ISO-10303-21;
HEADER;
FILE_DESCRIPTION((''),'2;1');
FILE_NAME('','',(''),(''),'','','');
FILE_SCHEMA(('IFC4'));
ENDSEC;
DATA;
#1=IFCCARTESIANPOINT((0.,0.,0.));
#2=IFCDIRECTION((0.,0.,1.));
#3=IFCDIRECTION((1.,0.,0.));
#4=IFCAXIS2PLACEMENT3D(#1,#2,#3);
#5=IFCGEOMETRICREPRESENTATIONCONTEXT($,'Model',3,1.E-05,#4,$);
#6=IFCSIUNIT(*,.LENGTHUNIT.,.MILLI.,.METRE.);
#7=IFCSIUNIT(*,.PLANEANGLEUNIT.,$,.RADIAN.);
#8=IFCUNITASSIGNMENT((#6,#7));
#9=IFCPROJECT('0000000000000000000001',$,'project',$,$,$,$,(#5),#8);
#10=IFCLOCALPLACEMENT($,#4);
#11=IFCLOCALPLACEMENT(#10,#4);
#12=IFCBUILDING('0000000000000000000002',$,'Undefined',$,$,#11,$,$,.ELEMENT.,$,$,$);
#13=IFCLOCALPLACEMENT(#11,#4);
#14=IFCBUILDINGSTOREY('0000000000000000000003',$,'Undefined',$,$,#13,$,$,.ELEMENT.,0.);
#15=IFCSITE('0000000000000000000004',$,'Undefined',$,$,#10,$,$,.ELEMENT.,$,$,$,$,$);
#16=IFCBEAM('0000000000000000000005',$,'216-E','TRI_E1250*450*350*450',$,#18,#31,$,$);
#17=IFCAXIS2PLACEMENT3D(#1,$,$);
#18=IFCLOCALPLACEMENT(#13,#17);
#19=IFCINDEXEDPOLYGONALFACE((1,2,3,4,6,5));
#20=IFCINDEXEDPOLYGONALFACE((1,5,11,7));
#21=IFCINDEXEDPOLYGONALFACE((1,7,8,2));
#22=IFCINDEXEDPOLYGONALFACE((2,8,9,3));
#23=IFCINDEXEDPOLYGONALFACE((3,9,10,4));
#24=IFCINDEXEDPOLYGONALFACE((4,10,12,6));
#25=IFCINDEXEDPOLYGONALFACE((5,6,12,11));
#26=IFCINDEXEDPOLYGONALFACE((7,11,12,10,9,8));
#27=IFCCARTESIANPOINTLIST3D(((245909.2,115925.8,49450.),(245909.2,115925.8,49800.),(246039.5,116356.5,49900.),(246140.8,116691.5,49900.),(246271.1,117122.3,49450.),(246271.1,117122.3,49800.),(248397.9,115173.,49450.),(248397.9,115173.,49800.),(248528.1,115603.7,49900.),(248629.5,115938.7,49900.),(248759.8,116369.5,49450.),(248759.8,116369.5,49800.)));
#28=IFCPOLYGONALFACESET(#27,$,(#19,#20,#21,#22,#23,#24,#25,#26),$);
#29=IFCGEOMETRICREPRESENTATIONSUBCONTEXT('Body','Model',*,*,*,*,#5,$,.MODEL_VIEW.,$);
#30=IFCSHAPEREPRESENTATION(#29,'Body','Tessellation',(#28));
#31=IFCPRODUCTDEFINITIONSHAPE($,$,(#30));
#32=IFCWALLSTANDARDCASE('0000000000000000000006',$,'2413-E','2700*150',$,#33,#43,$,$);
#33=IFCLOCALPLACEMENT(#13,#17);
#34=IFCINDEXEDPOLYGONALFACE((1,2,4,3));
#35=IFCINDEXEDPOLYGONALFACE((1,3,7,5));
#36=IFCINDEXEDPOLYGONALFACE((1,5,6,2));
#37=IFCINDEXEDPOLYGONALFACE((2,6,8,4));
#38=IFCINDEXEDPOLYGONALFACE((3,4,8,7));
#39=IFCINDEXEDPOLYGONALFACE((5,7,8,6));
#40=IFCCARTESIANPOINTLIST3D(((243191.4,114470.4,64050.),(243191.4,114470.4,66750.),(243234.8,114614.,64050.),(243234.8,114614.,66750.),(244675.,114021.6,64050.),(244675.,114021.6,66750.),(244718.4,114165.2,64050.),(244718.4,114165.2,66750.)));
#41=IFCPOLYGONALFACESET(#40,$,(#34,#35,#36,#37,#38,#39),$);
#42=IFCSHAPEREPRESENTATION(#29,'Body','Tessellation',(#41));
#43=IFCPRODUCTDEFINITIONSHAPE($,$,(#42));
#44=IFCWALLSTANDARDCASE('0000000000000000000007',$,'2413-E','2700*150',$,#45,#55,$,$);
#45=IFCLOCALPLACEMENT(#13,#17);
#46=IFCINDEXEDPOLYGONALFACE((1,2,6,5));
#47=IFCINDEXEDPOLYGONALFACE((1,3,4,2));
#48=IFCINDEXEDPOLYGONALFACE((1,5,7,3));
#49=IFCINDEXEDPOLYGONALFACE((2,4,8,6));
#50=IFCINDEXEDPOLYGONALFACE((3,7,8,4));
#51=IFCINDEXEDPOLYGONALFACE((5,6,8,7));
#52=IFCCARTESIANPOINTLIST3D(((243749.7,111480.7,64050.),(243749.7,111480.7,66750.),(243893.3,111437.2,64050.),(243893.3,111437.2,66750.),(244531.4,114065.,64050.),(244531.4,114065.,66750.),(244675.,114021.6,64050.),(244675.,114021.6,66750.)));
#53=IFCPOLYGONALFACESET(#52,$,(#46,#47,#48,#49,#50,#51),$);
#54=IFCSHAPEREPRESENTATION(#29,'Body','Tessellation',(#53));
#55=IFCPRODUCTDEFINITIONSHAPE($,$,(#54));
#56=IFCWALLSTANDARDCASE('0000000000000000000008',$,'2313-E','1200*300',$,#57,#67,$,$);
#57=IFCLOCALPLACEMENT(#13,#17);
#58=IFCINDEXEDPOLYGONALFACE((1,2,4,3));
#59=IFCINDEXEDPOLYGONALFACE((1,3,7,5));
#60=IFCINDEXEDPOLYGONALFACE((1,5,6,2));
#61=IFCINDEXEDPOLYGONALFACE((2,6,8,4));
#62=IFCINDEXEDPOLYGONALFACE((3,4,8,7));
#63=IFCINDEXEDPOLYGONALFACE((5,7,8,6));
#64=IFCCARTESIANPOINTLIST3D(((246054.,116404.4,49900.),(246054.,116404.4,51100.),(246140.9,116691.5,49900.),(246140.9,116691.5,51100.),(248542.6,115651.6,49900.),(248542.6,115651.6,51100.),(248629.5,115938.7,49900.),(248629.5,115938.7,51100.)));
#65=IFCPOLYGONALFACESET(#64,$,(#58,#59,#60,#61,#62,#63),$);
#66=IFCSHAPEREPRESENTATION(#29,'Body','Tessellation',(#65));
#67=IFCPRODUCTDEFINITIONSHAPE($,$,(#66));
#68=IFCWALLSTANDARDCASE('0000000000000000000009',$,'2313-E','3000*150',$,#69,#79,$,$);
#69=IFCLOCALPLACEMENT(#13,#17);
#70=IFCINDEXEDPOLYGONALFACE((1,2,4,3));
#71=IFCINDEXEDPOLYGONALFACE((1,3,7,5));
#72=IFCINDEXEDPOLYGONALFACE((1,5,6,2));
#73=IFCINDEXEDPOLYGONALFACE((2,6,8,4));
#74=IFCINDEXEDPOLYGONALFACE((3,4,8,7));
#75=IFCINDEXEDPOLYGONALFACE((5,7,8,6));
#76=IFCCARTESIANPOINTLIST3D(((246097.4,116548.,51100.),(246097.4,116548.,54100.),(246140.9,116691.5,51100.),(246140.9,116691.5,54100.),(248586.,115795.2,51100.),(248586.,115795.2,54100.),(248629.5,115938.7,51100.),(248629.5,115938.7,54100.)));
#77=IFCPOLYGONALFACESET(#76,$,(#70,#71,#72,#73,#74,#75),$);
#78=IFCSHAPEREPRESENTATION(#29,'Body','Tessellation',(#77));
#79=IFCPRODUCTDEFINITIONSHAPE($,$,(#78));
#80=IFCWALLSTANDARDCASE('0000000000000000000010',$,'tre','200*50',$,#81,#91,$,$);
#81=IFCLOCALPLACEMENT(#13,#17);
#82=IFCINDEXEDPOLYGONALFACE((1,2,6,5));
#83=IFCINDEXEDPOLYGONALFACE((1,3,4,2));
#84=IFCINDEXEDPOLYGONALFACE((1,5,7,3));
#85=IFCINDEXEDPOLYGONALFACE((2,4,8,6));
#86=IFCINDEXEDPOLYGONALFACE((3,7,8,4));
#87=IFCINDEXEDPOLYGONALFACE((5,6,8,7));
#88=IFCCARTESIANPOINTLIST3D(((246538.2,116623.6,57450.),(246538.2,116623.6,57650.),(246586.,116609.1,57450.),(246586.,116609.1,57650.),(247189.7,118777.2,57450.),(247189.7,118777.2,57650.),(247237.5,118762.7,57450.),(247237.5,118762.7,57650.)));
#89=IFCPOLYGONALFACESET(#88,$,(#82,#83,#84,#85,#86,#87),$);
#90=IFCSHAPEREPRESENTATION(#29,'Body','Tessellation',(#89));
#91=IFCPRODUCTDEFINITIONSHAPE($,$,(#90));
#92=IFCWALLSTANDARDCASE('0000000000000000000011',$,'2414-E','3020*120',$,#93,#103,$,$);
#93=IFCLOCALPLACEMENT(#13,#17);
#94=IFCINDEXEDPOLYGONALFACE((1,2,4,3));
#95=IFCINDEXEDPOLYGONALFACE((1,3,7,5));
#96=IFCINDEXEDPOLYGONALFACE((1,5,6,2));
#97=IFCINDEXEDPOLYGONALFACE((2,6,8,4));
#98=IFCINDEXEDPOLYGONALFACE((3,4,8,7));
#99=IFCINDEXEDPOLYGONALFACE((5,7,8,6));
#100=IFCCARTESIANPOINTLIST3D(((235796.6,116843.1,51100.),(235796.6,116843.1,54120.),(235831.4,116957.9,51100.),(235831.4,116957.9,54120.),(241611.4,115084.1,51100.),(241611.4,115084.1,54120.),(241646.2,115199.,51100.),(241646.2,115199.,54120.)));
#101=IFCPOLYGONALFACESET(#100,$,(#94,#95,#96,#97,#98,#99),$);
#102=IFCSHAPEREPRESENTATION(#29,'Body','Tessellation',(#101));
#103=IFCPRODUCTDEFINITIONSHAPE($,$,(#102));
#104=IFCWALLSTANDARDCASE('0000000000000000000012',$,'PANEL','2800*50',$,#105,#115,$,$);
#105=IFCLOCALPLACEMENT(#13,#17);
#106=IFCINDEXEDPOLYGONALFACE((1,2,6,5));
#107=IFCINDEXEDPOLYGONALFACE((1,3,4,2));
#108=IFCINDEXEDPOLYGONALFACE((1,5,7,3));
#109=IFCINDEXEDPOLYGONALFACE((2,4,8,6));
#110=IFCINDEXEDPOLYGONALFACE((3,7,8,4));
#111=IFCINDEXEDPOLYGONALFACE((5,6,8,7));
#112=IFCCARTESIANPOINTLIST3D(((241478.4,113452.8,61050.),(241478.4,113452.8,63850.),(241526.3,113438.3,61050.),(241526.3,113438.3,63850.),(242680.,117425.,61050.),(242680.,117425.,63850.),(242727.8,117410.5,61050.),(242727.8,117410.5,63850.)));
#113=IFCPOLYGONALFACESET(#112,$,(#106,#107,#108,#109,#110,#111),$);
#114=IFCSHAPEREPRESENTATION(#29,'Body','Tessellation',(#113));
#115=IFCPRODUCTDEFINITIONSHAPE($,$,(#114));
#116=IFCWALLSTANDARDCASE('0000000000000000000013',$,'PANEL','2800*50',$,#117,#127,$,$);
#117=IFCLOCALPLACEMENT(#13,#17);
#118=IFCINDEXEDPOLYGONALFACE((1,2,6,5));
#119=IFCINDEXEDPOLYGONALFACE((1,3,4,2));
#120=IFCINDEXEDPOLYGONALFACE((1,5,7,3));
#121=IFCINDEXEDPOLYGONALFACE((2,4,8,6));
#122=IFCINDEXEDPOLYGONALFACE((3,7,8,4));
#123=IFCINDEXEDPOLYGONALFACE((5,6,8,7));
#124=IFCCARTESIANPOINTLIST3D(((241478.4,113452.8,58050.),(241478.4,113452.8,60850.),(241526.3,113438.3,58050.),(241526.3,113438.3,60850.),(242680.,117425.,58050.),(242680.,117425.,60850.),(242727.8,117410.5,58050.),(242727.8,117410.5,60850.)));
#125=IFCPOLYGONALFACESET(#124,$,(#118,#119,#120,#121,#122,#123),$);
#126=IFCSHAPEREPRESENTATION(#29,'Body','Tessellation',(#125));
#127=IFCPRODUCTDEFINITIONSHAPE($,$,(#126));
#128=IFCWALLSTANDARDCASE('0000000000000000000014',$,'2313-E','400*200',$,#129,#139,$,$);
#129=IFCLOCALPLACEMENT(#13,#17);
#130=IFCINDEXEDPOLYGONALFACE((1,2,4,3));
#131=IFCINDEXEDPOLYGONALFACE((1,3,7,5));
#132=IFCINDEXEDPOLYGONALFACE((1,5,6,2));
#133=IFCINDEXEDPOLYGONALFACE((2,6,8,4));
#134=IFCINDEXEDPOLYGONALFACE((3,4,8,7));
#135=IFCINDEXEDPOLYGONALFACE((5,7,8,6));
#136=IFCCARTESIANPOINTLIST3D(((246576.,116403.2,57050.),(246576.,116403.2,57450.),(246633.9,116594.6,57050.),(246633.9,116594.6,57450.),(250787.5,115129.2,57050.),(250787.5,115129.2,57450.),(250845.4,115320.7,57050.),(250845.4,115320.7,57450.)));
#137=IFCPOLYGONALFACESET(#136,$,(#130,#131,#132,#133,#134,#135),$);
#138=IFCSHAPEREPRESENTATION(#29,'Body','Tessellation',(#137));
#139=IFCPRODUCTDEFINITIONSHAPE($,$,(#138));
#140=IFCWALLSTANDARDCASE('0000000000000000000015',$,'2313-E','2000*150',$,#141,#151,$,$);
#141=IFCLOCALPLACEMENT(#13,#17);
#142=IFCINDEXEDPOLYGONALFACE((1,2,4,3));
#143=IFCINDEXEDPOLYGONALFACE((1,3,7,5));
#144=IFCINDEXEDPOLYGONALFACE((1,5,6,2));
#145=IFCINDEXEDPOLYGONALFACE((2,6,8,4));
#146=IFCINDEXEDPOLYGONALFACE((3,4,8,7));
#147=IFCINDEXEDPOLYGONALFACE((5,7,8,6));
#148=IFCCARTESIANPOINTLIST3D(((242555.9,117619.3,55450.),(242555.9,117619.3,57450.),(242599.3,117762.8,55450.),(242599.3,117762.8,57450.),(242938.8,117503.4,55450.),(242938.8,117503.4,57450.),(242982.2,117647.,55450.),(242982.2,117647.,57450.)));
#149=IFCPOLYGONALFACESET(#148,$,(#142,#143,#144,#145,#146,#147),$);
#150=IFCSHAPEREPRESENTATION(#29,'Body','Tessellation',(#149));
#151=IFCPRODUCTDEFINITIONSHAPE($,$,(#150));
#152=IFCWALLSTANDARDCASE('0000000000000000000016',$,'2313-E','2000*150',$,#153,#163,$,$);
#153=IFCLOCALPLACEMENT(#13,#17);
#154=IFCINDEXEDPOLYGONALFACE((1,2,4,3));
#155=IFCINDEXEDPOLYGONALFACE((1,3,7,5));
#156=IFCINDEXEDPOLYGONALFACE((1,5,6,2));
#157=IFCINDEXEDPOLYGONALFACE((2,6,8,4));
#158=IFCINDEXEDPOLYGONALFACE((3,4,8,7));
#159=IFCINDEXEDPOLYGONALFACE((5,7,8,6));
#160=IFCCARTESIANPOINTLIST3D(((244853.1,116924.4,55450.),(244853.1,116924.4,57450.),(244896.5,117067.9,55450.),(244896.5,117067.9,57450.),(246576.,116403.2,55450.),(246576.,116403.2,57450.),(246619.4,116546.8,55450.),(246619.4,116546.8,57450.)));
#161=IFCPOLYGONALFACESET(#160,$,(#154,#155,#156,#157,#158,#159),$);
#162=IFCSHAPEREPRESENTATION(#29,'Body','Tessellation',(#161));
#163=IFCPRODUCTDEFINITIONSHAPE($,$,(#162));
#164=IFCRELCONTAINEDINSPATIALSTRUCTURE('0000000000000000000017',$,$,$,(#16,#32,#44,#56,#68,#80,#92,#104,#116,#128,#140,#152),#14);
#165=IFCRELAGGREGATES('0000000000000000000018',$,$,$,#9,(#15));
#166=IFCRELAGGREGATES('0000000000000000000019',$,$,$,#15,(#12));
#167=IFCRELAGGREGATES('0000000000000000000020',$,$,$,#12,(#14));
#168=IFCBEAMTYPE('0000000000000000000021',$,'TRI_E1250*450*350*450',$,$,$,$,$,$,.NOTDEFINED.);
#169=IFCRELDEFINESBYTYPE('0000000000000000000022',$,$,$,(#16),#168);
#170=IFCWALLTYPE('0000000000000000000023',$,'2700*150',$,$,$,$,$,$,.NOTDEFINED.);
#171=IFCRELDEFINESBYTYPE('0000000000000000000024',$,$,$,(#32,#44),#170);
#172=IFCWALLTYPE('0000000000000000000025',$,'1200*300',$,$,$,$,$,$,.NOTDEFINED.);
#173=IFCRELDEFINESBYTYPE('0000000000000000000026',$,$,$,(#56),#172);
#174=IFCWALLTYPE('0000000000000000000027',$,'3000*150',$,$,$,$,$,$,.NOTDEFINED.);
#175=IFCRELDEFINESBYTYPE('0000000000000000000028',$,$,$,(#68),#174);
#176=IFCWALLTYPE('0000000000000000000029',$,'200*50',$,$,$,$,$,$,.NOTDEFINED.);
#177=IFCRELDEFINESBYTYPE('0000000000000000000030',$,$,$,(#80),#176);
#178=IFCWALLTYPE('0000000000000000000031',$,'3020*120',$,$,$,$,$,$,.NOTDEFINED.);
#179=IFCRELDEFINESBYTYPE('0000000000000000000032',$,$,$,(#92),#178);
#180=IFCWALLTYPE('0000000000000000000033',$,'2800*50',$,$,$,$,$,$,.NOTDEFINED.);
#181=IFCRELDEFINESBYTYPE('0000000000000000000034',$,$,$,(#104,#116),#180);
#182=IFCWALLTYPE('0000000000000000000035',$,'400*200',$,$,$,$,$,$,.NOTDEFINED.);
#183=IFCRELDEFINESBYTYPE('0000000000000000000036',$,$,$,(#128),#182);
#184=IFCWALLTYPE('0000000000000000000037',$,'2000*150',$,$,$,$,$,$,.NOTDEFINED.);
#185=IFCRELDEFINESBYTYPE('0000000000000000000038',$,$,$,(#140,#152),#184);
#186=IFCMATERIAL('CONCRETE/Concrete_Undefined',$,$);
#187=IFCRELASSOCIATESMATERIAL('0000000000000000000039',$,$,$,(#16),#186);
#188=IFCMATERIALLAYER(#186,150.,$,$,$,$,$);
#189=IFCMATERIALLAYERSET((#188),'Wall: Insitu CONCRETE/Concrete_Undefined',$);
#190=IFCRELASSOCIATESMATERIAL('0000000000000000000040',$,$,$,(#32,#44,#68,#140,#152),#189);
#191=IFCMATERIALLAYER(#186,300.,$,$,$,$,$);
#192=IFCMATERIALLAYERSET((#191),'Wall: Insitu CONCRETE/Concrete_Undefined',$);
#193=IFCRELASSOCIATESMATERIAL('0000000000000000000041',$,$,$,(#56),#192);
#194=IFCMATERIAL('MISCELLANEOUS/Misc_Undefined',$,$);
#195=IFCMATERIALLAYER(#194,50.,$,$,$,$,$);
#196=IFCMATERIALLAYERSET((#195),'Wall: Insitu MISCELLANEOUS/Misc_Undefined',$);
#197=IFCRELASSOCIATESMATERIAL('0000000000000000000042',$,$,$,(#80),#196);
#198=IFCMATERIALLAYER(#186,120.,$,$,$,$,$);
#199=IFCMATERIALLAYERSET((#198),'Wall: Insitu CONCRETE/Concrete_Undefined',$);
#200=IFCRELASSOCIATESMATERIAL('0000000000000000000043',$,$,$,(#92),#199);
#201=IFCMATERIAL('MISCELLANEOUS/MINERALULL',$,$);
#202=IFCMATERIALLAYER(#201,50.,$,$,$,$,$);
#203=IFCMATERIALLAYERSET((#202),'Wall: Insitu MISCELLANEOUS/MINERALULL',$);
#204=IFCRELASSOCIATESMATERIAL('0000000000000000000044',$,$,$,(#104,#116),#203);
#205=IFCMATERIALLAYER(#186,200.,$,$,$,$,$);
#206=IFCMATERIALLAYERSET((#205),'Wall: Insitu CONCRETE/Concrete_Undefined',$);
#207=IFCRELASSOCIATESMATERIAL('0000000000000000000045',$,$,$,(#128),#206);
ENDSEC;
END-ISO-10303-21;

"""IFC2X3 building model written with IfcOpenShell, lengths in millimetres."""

from ifc_helpers import new_model, si_unit, frame, frame_2d, origin_with_axes, place, context, subcontext, project, spatial, polyline, rectangle, outline, extrude, material, layer, layer_set, layer_usage, type_object, element, save


model = new_model("IFC2X3")

# Units and contexts
model_context = context("Model", 3, precision=1e-05, world=origin_with_axes())
body_context = subcontext(model_context, "Body", "Model", "MODEL_VIEW")
ifc_project = project(units=[si_unit("LENGTHUNIT", "METRE", prefix="MILLI"), si_unit("PLANEANGLEUNIT", "RADIAN")], contexts=[model_context])

# Site, building, storey
site_placement = place(None, origin_with_axes())
site = spatial("IfcSite", under=ifc_project, at=site_placement, Name="Undefined", CompositionType="ELEMENT")
building_placement = place(site_placement, origin_with_axes())
building = spatial("IfcBuilding", under=site, at=building_placement, Name="Undefined", CompositionType="ELEMENT")
storey_placement = place(building_placement, origin_with_axes())
storey = spatial("IfcBuildingStorey", under=building, at=storey_placement, Name="Undefined", CompositionType="ELEMENT", Elevation=0.0)

# Beam
ifc_material_1 = material(Name="MISCELLANEOUS/Misc_Undefined")
ifc_material_2 = material(Name="CONCRETE/Concrete_Undefined")
beam_type_1 = type_object("IfcBeamType", Name="TRI_E1250*450*350*450", PredefinedType="NOTDEFINED")
beam_1_placement = place(storey_placement, frame((246090.2, 116524.0, 49675.0), z_axis=(0.0, 0.0, 1.0), x_axis=(0.957167, -0.289538, 0.0)))
element("IfcBeam", 1, at=beam_1_placement, inside=storey, type_object=beam_type_1, material=ifc_material_2, Name="216-E", Description="TRI_E1250*450*350*450", context=body_context, shape_type="SweptSolid", body=[
    extrude(outline(polyline([(625.0, -225.0), (-625.0, -225.0), (-625.0, 125.0), (-175.0, 225.0), (175.0, 225.0), (625.0, 125.0), (625.0, -225.0)])), frame((2600.0, 0.0, 0.0), z_axis=(-1.0, 0.0, 0.0), x_axis=(0.0, -1.0, 0.0)), (0.0, 0.0, 1.0), 2600.0),
])

# Walls
ifc_layer_1 = layer(ifc_material_2, 150.0)
ifc_layer_set_1 = layer_set([ifc_layer_1], Name="Wall: Insitu CONCRETE/Concrete_Undefined")
ifc_layer_usage_1 = layer_usage(ifc_layer_set_1, "AXIS2", "POSITIVE", -75.0)
wall_type_1 = type_object("IfcWallType", Name="2700*150", PredefinedType="NOTDEFINED")
wall_1_placement = place(storey_placement, frame((243213.1, 114542.2, 64050.0), z_axis=(0.0, 0.0, 1.0), x_axis=(0.957168, -0.289533, 0.0)))
element("IfcWallStandardCase", 2, at=wall_1_placement, inside=storey, type_object=wall_type_1, material=ifc_layer_usage_1, Name="2413-E", Description="2700*150", context=body_context, shape_type="SweptSolid", body=[
    extrude(rectangle(XDim=1550.0, YDim=150.0, at=frame_2d((0.0, 775.0), x_axis=(0.0, -1.0))), frame((0.0, 0.0, 0.0), z_axis=(0.0, 0.0, 1.0), x_axis=(0.0, -1.0, 0.0)), (0.0, 0.0, 1.0), 2700.0),
])
ifc_layer_usage_2 = layer_usage(ifc_layer_set_1, "AXIS2", "POSITIVE", -75.0)
wall_2_placement = place(storey_placement, frame((244603.2, 114043.3, 64050.0), z_axis=(0.0, 0.0, 1.0), x_axis=(-0.289536, -0.957167, 0.0)))
element("IfcWallStandardCase", 3, at=wall_2_placement, inside=storey, type_object=wall_type_1, material=ifc_layer_usage_2, Name="2413-E", Description="2700*150", context=body_context, shape_type="SweptSolid", body=[
    extrude(rectangle(XDim=2700.0, YDim=150.0, at=frame_2d((0.0, 1350.0), x_axis=(0.0, -1.0))), frame((0.0, 0.0, 0.0), z_axis=(0.0, 0.0, 1.0), x_axis=(0.0, -1.0, 0.0)), (0.0, 0.0, 1.0), 2700.0),
])
ifc_layer_2 = layer(ifc_material_2, 300.0)
ifc_layer_set_2 = layer_set([ifc_layer_2], Name="Wall: Insitu CONCRETE/Concrete_Undefined")
ifc_layer_usage_3 = layer_usage(ifc_layer_set_2, "AXIS2", "POSITIVE", -150.0)
wall_type_2 = type_object("IfcWallType", Name="1200*300", PredefinedType="NOTDEFINED")
wall_3_placement = place(storey_placement, frame((246097.4, 116548.0, 49900.0), z_axis=(0.0, 0.0, 1.0), x_axis=(0.957166, -0.289541, 0.0)))
element("IfcWallStandardCase", 4, at=wall_3_placement, inside=storey, type_object=wall_type_2, material=ifc_layer_usage_3, Name="2313-E", Description="1200*300", context=body_context, shape_type="SweptSolid", body=[
    extrude(rectangle(XDim=2600.0, YDim=300.0, at=frame_2d((0.0, 1300.0), x_axis=(0.0, -1.0))), frame((0.0, 0.0, 0.0), z_axis=(0.0, 0.0, 1.0), x_axis=(0.0, -1.0, 0.0)), (0.0, 0.0, 1.0), 1200.0),
])
ifc_layer_usage_4 = layer_usage(ifc_layer_set_1, "AXIS2", "POSITIVE", -75.0)
wall_type_3 = type_object("IfcWallType", Name="3000*150", PredefinedType="NOTDEFINED")
wall_4_placement = place(storey_placement, frame((246119.1, 116619.8, 51100.0), z_axis=(0.0, 0.0, 1.0), x_axis=(0.957166, -0.289541, 0.0)))
element("IfcWallStandardCase", 5, at=wall_4_placement, inside=storey, type_object=wall_type_3, material=ifc_layer_usage_4, Name="2313-E", Description="3000*150", context=body_context, shape_type="SweptSolid", body=[
    extrude(rectangle(XDim=2600.0, YDim=150.0, at=frame_2d((0.0, 1300.0), x_axis=(0.0, -1.0))), frame((0.0, 0.0, 0.0), z_axis=(0.0, 0.0, 1.0), x_axis=(0.0, -1.0, 0.0)), (0.0, 0.0, 1.0), 3000.0),
])
ifc_layer_3 = layer(ifc_material_1, 50.0)
ifc_layer_set_3 = layer_set([ifc_layer_3], Name="Wall: Insitu MISCELLANEOUS/Misc_Undefined")
ifc_layer_usage_5 = layer_usage(ifc_layer_set_3, "AXIS2", "POSITIVE", -25.0)
wall_type_4 = type_object("IfcWallType", Name="200*50", PredefinedType="NOTDEFINED")
wall_5_placement = place(storey_placement, frame((247213.6, 118770.0, 57450.0), z_axis=(0.0, 0.0, 1.0), x_axis=(-0.289539, -0.957166, 0.0)))
element("IfcWallStandardCase", 6, at=wall_5_placement, inside=storey, type_object=wall_type_4, material=ifc_layer_usage_5, Name="tre", Description="200*50", context=body_context, shape_type="SweptSolid", body=[
    extrude(rectangle(XDim=2250.0, YDim=50.0, at=frame_2d((0.0, 1125.0), x_axis=(0.0, -1.0))), frame((0.0, 0.0, 0.0), z_axis=(0.0, 0.0, 1.0), x_axis=(0.0, -1.0, 0.0)), (0.0, 0.0, 1.0), 200.0),
])
ifc_layer_4 = layer(ifc_material_2, 120.0)
ifc_layer_set_4 = layer_set([ifc_layer_4], Name="Wall: Insitu CONCRETE/Concrete_Undefined")
ifc_layer_usage_6 = layer_usage(ifc_layer_set_4, "AXIS2", "POSITIVE", -60.0)
wall_type_5 = type_object("IfcWallType", Name="3020*120", PredefinedType="NOTDEFINED")
wall_6_placement = place(storey_placement, frame((241628.8, 115141.5, 51100.0), z_axis=(0.0, 0.0, 1.0), x_axis=(-0.957166, 0.289541, 0.0)))
element("IfcWallStandardCase", 7, at=wall_6_placement, inside=storey, type_object=wall_type_5, material=ifc_layer_usage_6, Name="2414-E", Description="3020*120", context=body_context, shape_type="SweptSolid", body=[
    extrude(rectangle(XDim=6075.0, YDim=120.0, at=frame_2d((0.0, 3037.5), x_axis=(0.0, -1.0))), frame((0.0, 0.0, 0.0), z_axis=(0.0, 0.0, 1.0), x_axis=(0.0, -1.0, 0.0)), (0.0, 0.0, 1.0), 3020.0),
])
ifc_material_3 = material(Name="MISCELLANEOUS/MINERALULL")
ifc_layer_5 = layer(ifc_material_3, 50.0)
ifc_layer_set_5 = layer_set([ifc_layer_5], Name="Wall: Insitu MISCELLANEOUS/MINERALULL")
ifc_layer_usage_7 = layer_usage(ifc_layer_set_5, "AXIS2", "POSITIVE", -25.0)
wall_type_6 = type_object("IfcWallType", Name="2800*50", PredefinedType="NOTDEFINED")
wall_7_placement = place(storey_placement, frame((241502.3, 113445.5, 61050.0), z_axis=(0.0, 0.0, 1.0), x_axis=(0.289537, 0.957167, 0.0)))
element("IfcWallStandardCase", 8, at=wall_7_placement, inside=storey, type_object=wall_type_6, material=ifc_layer_usage_7, Name="PANEL", Description="2800*50", context=body_context, shape_type="SweptSolid", body=[
    extrude(rectangle(XDim=4150.0, YDim=50.0, at=frame_2d((0.0, 2075.0), x_axis=(0.0, -1.0))), frame((0.0, 0.0, 0.0), z_axis=(0.0, 0.0, 1.0), x_axis=(0.0, -1.0, 0.0)), (0.0, 0.0, 1.0), 2800.0),
])
ifc_layer_usage_8 = layer_usage(ifc_layer_set_5, "AXIS2", "POSITIVE", -25.0)
wall_8_placement = place(storey_placement, frame((241502.3, 113445.5, 58050.0), z_axis=(0.0, 0.0, 1.0), x_axis=(0.289537, 0.957167, 0.0)))
element("IfcWallStandardCase", 9, at=wall_8_placement, inside=storey, type_object=wall_type_6, material=ifc_layer_usage_8, Name="PANEL", Description="2800*50", context=body_context, shape_type="SweptSolid", body=[
    extrude(rectangle(XDim=4150.0, YDim=50.0, at=frame_2d((0.0, 2075.0), x_axis=(0.0, -1.0))), frame((0.0, 0.0, 0.0), z_axis=(0.0, 0.0, 1.0), x_axis=(0.0, -1.0, 0.0)), (0.0, 0.0, 1.0), 2800.0),
])
ifc_layer_6 = layer(ifc_material_2, 200.0)
ifc_layer_set_6 = layer_set([ifc_layer_6], Name="Wall: Insitu CONCRETE/Concrete_Undefined")
ifc_layer_usage_9 = layer_usage(ifc_layer_set_6, "AXIS2", "POSITIVE", -100.0)
wall_type_7 = type_object("IfcWallType", Name="400*200", PredefinedType="NOTDEFINED")
wall_9_placement = place(storey_placement, frame((246605.0, 116498.9, 57050.0), z_axis=(0.0, 0.0, 1.0), x_axis=(0.957166, -0.289539, 0.0)))
element("IfcWallStandardCase", 10, at=wall_9_placement, inside=storey, type_object=wall_type_7, material=ifc_layer_usage_9, Name="2313-E", Description="400*200", context=body_context, shape_type="SweptSolid", body=[
    extrude(rectangle(XDim=4400.0, YDim=200.0, at=frame_2d((0.0, 2200.0), x_axis=(0.0, -1.0))), frame((0.0, 0.0, 0.0), z_axis=(0.0, 0.0, 1.0), x_axis=(0.0, -1.0, 0.0)), (0.0, 0.0, 1.0), 400.0),
])
ifc_layer_usage_10 = layer_usage(ifc_layer_set_1, "AXIS2", "POSITIVE", -75.0)
wall_type_8 = type_object("IfcWallType", Name="2000*150", PredefinedType="NOTDEFINED")
wall_10_placement = place(storey_placement, frame((242577.6, 117691.0, 55450.0), z_axis=(0.0, 0.0, 1.0), x_axis=(0.957161, -0.289556, 0.0)))
element("IfcWallStandardCase", 11, at=wall_10_placement, inside=storey, type_object=wall_type_8, material=ifc_layer_usage_10, Name="2313-E", Description="2000*150", context=body_context, shape_type="SweptSolid", body=[
    extrude(rectangle(XDim=400.0, YDim=150.0, at=frame_2d((0.0, 200.0), x_axis=(0.0, -1.0))), frame((0.0, 0.0, 0.0), z_axis=(0.0, 0.0, 1.0), x_axis=(0.0, -1.0, 0.0)), (0.0, 0.0, 1.0), 2000.0),
])
ifc_layer_usage_11 = layer_usage(ifc_layer_set_1, "AXIS2", "POSITIVE", -75.0)
wall_11_placement = place(storey_placement, frame((244874.8, 116996.2, 55450.0), z_axis=(0.0, 0.0, 1.0), x_axis=(0.957166, -0.289541, 0.0)))
element("IfcWallStandardCase", 12, at=wall_11_placement, inside=storey, type_object=wall_type_8, material=ifc_layer_usage_11, Name="2313-E", Description="2000*150", context=body_context, shape_type="SweptSolid", body=[
    extrude(rectangle(XDim=1800.0, YDim=150.0, at=frame_2d((0.0, 900.0), x_axis=(0.0, -1.0))), frame((0.0, 0.0, 0.0), z_axis=(0.0, 0.0, 1.0), x_axis=(0.0, -1.0, 0.0)), (0.0, 0.0, 1.0), 2000.0),
])

save(model, "model.ifc")
